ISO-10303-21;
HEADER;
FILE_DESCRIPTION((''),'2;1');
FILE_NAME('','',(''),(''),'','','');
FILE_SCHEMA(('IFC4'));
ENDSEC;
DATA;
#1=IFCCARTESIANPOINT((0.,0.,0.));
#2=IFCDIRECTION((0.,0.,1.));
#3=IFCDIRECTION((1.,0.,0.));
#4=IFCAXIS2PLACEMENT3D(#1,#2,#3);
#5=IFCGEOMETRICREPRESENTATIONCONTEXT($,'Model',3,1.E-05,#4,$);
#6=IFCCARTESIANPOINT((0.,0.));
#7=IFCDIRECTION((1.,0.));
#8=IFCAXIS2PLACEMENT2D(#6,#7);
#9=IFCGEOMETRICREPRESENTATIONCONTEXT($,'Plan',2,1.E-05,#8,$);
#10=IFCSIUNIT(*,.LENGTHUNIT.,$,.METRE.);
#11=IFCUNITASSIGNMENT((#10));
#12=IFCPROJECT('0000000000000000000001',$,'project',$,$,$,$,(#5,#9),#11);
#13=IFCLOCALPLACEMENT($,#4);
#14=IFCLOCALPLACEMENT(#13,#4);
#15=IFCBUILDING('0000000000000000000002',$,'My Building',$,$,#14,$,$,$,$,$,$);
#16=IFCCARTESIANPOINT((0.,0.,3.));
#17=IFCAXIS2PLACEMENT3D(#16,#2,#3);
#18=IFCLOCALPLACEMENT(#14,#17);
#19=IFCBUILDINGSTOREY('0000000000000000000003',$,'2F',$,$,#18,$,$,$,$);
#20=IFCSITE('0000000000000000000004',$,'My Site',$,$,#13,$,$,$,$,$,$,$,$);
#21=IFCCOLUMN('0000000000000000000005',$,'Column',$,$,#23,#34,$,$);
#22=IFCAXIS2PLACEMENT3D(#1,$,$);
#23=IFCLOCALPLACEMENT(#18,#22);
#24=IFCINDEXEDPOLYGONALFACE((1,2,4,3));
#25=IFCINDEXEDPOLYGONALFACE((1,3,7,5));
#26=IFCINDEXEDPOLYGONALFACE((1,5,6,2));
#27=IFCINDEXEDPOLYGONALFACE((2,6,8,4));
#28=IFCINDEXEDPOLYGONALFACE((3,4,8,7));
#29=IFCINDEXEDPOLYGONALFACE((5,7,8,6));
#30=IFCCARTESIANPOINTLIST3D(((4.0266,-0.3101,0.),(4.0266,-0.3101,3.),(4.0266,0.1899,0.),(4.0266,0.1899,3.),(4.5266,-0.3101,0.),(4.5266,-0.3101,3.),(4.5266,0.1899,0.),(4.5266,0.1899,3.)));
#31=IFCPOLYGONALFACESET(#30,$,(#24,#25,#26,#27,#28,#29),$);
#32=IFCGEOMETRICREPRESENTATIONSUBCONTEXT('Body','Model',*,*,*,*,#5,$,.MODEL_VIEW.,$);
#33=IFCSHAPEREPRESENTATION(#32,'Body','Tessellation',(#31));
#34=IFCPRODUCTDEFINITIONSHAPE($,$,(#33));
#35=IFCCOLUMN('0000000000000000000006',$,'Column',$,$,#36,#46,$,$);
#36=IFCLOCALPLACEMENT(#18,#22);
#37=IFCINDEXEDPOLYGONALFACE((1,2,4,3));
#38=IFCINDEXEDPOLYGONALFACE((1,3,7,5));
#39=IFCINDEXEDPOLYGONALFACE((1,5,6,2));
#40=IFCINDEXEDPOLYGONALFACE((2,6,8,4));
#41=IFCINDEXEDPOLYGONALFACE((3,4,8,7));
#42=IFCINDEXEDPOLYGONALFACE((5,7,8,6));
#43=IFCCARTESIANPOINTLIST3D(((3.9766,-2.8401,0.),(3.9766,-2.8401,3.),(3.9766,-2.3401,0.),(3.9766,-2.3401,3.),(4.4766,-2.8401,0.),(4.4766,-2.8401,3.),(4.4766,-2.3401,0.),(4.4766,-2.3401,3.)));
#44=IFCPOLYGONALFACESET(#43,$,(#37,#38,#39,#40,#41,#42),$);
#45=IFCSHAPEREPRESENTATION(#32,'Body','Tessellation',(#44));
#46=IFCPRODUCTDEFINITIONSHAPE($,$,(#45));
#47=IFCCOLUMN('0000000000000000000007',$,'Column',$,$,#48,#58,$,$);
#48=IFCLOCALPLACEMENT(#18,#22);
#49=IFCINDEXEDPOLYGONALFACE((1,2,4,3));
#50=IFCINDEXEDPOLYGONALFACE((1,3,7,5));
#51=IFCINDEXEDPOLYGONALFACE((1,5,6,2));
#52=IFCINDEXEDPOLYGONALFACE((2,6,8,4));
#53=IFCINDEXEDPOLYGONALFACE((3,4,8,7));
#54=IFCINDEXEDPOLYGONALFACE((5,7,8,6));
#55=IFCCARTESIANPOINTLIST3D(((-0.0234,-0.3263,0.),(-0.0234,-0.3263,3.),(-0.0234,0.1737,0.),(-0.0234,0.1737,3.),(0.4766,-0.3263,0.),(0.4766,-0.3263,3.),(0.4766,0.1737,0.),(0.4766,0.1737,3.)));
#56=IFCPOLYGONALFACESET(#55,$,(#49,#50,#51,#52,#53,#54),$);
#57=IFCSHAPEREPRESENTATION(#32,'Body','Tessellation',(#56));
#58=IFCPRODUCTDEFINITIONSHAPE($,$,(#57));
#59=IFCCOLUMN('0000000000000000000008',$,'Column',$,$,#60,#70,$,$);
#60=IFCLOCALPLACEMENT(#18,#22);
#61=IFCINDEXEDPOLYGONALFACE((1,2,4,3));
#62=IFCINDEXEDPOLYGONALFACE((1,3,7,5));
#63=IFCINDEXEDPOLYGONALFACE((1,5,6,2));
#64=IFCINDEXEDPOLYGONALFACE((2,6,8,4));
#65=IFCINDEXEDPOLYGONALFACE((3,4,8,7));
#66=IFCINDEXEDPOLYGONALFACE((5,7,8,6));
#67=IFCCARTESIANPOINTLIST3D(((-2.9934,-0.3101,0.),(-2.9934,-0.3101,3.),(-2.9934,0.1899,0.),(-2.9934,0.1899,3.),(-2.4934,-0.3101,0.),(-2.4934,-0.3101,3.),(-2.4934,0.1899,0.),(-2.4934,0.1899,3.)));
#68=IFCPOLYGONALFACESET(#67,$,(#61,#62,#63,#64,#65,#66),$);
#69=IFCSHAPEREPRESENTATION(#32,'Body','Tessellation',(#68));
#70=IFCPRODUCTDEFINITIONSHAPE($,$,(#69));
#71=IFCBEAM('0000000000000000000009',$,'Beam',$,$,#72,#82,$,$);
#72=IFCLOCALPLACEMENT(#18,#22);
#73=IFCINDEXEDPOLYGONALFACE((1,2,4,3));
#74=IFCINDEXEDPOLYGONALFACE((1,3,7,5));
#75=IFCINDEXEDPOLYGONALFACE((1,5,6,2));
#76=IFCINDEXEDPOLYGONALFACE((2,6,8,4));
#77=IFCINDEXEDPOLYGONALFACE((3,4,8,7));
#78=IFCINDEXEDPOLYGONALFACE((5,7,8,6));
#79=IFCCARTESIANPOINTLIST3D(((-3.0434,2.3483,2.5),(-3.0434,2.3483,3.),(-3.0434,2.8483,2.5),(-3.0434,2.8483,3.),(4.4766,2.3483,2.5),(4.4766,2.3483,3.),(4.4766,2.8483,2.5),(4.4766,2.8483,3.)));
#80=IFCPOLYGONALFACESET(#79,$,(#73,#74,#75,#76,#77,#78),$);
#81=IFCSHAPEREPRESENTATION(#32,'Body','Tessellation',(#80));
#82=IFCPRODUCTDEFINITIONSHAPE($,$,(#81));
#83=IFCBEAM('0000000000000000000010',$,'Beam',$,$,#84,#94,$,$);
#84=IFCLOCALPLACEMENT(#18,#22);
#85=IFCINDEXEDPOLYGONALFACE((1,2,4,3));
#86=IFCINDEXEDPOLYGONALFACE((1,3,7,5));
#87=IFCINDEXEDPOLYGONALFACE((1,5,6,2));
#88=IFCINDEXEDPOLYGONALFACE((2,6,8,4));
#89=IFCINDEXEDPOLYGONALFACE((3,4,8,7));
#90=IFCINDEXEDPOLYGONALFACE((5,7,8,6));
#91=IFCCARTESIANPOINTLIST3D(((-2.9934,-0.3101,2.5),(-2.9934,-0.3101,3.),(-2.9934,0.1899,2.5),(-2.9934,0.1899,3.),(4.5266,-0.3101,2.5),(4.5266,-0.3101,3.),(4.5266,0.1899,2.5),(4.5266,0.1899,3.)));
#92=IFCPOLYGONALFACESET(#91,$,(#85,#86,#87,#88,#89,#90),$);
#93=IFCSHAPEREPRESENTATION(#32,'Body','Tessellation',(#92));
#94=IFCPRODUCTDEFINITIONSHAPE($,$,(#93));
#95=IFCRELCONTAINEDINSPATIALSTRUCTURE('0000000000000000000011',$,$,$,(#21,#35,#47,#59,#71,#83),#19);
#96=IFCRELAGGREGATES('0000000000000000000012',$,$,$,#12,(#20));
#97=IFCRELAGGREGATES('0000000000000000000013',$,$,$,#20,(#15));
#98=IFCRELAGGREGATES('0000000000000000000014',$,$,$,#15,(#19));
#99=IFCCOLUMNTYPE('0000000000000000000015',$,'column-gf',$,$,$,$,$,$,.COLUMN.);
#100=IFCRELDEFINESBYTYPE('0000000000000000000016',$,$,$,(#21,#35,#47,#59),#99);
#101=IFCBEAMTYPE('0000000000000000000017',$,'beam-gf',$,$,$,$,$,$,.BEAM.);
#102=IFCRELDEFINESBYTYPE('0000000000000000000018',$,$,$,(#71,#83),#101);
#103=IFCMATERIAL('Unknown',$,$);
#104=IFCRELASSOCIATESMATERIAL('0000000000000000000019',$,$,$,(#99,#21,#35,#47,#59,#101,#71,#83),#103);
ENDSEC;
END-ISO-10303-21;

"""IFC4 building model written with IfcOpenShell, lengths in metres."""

from ifc_helpers import new_model, si_unit, frame, origin_with_axes, origin_2d_with_axis, place, context, subcontext, project, spatial, rectangle, extrude, material, material_profile, profile_set, profile_usage, type_object, element, save


model = new_model("IFC4")

# Units and contexts
model_context = context("Model", 3, precision=1e-05, world=origin_with_axes())
plan_context = context("Plan", 2, precision=1e-05, world=origin_2d_with_axis())
body_context_1 = subcontext(model_context, "Body", "Model", "MODEL_VIEW")
ifc_project = project(units=[si_unit("LENGTHUNIT", "METRE")], contexts=[model_context, plan_context])

# Site, building, storey
site_placement = place(None, origin_with_axes())
site = spatial("IfcSite", under=ifc_project, at=site_placement, Name="My Site")
building_placement = place(site_placement, origin_with_axes())
building = spatial("IfcBuilding", under=site, at=building_placement, Name="My Building")
storey_placement = place(building_placement, frame((0.0, 0.0, 3.0), z_axis=(0.0, 0.0, 1.0), x_axis=(1.0, 0.0, 0.0)))
storey = spatial("IfcBuildingStorey", under=building, at=storey_placement, Name="2F")

# Columns
ifc_material = material(Name="Unknown")
ifc_material_profile_1 = material_profile(ifc_material, rectangle(XDim=0.5, YDim=0.5))
ifc_profile_set_1 = profile_set([ifc_material_profile_1])
ifc_profile_usage_1 = profile_usage(ifc_profile_set_1, cardinal=7)
column_type = type_object("IfcColumnType", Name="column-gf", PredefinedType="COLUMN", material=ifc_profile_set_1)
column_1_placement = place(storey_placement, frame((4.5266, 0.1899, 0.0), z_axis=(0.0, 0.0, 1.0), x_axis=(1.0, 0.0, 0.0)))
element("IfcColumn", 1, at=column_1_placement, inside=storey, type_object=column_type, material=ifc_profile_usage_1, Name="Column", context=body_context_1, shape_type="SweptSolid", body=[
    extrude(rectangle(XDim=0.5, YDim=0.5), frame((-0.25, -0.25, 0.0), z_axis=(0.0, 0.0, 1.0), x_axis=(1.0, 0.0, 0.0)), (0.0, 0.0, 1.0), 3.0),
])
ifc_profile_usage_2 = profile_usage(ifc_profile_set_1, cardinal=7)
column_2_placement = place(storey_placement, frame((4.4766, -2.3401, 0.0), z_axis=(0.0, 0.0, 1.0), x_axis=(1.0, 0.0, 0.0)))
element("IfcColumn", 2, at=column_2_placement, inside=storey, type_object=column_type, material=ifc_profile_usage_2, Name="Column", context=body_context_1, shape_type="SweptSolid", body=[
    extrude(rectangle(XDim=0.5, YDim=0.5), frame((-0.25, -0.25, 0.0), z_axis=(0.0, 0.0, 1.0), x_axis=(1.0, 0.0, 0.0)), (0.0, 0.0, 1.0), 3.0),
])
ifc_profile_usage_3 = profile_usage(ifc_profile_set_1, cardinal=7)
column_3_placement = place(storey_placement, frame((0.4766, 0.1737, 0.0), z_axis=(0.0, 0.0, 1.0), x_axis=(1.0, 0.0, 0.0)))
element("IfcColumn", 3, at=column_3_placement, inside=storey, type_object=column_type, material=ifc_profile_usage_3, Name="Column", context=body_context_1, shape_type="SweptSolid", body=[
    extrude(rectangle(XDim=0.5, YDim=0.5), frame((-0.25, -0.25, 0.0), z_axis=(0.0, 0.0, 1.0), x_axis=(1.0, 0.0, 0.0)), (0.0, 0.0, 1.0), 3.0),
])
ifc_profile_usage_4 = profile_usage(ifc_profile_set_1, cardinal=7)
column_4_placement = place(storey_placement, frame((-2.4934, 0.1899, 0.0), z_axis=(0.0, 0.0, 1.0), x_axis=(1.0, 0.0, 0.0)))
element("IfcColumn", 4, at=column_4_placement, inside=storey, type_object=column_type, material=ifc_profile_usage_4, Name="Column", context=body_context_1, shape_type="SweptSolid", body=[
    extrude(rectangle(XDim=0.5, YDim=0.5), frame((-0.25, -0.25, 0.0), z_axis=(0.0, 0.0, 1.0), x_axis=(1.0, 0.0, 0.0)), (0.0, 0.0, 1.0), 3.0),
])

# Beams
ifc_material_profile_2 = material_profile(ifc_material, rectangle(XDim=0.5, YDim=0.5))
ifc_profile_set_2 = profile_set([ifc_material_profile_2])
ifc_profile_usage_5 = profile_usage(ifc_profile_set_2, cardinal=7)
beam_type = type_object("IfcBeamType", Name="beam-gf", PredefinedType="BEAM", material=ifc_profile_set_2)
beam_1_placement = place(storey_placement, frame((4.4766, 2.3483, 3.0), z_axis=(-1.0, 0.0, 0.0), x_axis=(0.0, -1.0, 0.0)))
element("IfcBeam", 5, at=beam_1_placement, inside=storey, type_object=beam_type, material=ifc_profile_usage_5, Name="Beam", context=body_context_1, shape_type="SweptSolid", body=[
    extrude(rectangle(XDim=0.5, YDim=0.5), frame((-0.25, -0.25, 0.0), z_axis=(0.0, 0.0, 1.0), x_axis=(1.0, 0.0, 0.0)), (0.0, 0.0, 1.0), 7.52),
])
ifc_profile_usage_6 = profile_usage(ifc_profile_set_2, cardinal=7)
beam_2_placement = place(storey_placement, frame((4.5266, -0.3101, 3.0), z_axis=(-1.0, 0.0, 0.0), x_axis=(0.0, -1.0, 0.0)))
element("IfcBeam", 6, at=beam_2_placement, inside=storey, type_object=beam_type, material=ifc_profile_usage_6, Name="Beam", context=body_context_1, shape_type="SweptSolid", body=[
    extrude(rectangle(XDim=0.5, YDim=0.5), frame((-0.25, -0.25, 0.0), z_axis=(0.0, 0.0, 1.0), x_axis=(1.0, 0.0, 0.0)), (0.0, 0.0, 1.0), 7.52),
])

save(model, "model.ifc")
